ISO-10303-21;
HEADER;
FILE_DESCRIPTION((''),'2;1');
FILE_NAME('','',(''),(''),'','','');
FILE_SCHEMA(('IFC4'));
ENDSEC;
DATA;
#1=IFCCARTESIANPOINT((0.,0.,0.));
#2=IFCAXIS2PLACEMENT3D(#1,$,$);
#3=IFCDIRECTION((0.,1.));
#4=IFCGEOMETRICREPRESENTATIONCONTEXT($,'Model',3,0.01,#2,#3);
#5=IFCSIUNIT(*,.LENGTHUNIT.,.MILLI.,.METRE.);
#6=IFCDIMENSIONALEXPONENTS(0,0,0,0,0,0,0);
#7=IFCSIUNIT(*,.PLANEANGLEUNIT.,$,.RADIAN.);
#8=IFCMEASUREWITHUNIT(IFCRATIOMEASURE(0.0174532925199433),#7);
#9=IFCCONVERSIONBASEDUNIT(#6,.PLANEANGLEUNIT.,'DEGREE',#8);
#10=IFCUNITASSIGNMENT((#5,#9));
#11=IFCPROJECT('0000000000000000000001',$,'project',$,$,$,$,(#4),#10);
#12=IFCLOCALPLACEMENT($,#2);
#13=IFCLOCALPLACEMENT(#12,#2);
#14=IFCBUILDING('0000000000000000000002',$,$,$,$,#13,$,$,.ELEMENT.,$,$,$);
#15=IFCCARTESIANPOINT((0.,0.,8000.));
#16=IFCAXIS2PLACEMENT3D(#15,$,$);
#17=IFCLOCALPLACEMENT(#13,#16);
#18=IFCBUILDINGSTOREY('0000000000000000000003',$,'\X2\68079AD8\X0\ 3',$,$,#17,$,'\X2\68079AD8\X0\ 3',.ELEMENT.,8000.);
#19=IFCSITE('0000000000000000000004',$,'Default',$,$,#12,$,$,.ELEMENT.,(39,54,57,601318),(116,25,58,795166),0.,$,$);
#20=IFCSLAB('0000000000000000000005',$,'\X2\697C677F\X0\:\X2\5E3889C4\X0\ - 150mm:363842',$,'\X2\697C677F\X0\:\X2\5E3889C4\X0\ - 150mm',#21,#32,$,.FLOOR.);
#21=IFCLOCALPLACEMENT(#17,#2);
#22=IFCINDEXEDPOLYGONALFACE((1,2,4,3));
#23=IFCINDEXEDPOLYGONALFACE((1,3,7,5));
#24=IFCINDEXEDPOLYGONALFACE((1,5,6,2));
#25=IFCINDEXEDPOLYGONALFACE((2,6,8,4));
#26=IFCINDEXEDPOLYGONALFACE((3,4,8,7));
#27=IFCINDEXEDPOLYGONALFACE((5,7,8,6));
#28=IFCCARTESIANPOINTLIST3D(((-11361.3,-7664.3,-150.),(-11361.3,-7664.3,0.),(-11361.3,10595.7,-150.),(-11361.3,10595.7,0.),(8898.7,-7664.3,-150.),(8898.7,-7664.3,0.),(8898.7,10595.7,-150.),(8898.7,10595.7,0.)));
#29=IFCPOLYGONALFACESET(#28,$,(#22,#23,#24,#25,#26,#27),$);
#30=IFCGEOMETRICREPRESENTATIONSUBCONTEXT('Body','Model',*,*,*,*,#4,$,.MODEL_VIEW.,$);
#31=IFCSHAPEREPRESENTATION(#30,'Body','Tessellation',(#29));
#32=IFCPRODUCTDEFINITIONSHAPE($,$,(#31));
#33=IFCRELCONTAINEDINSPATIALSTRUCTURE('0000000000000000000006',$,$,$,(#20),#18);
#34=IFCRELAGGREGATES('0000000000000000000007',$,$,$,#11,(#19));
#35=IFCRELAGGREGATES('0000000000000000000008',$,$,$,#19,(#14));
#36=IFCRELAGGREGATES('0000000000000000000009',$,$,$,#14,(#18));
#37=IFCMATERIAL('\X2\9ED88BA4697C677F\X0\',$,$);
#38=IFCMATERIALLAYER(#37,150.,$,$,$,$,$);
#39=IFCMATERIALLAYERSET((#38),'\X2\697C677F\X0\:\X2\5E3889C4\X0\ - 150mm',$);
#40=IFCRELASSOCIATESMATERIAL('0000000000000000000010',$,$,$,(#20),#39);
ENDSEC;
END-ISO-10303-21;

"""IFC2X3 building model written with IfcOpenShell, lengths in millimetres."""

from ifc_helpers import new_model, entity, si_unit, converted_unit, direction, frame, frame_2d, origin, place, context, subcontext, project, spatial, rectangle, extrude, material, layer, layer_set, layer_usage, element, save


model = new_model("IFC2X3")

# Units and contexts
model_context = context("Model", 3, precision=0.01, world=origin(), true_north=direction((0.0, 1.0)))
body_context = subcontext(model_context, "Body", "Model", "MODEL_VIEW")
ifc_project = project(units=[si_unit("LENGTHUNIT", "METRE", prefix="MILLI"), converted_unit("PLANEANGLEUNIT", "DEGREE", entity("IfcRatioMeasure", 0.0174532925199433), si_unit("PLANEANGLEUNIT", "RADIAN"), dimensions=[0, 0, 0, 0, 0, 0, 0])], contexts=[model_context])

# Site, building, storey
site_placement = place(None, origin())
site = spatial("IfcSite", under=ifc_project, at=site_placement, Name="Default", CompositionType="ELEMENT", RefLatitude=(39, 54, 57, 601318), RefLongitude=(116, 25, 58, 795166), RefElevation=0.0)
building_placement = place(site_placement, origin())
building = spatial("IfcBuilding", under=site, at=building_placement, CompositionType="ELEMENT")
storey_placement = place(building_placement, frame((0.0, 0.0, 8000.0)))
storey = spatial("IfcBuildingStorey", under=building, at=storey_placement, Name="标高 3", LongName="标高 3", CompositionType="ELEMENT", Elevation=8000.0)

# Slab
ifc_material_1 = material(Name="默认楼板")
ifc_layer = layer(ifc_material_1, 150.0)
ifc_layer_set = layer_set([ifc_layer], Name="楼板:常规 - 150mm")
ifc_layer_usage = layer_usage(ifc_layer_set, "AXIS3", "POSITIVE", 0.0)
slab_placement = place(storey_placement, origin())
element("IfcSlab", 1, at=slab_placement, inside=storey, material=ifc_layer_usage, Name="楼板:常规 - 150mm:363842", ObjectType="楼板:常规 - 150mm", PredefinedType="FLOOR", context=body_context, shape_type="SweptSolid", body=[
    extrude(rectangle(XDim=18260.0, YDim=20260.0, at=frame_2d((0.0, 0.0), x_axis=(1.0, 0.0))), frame((-1231.3, 1465.7, 0.0), z_axis=(0.0, 0.0, -1.0), x_axis=(0.0, 1.0, 0.0)), (0.0, 0.0, 1.0), 150.0),
])

save(model, "model.ifc")
